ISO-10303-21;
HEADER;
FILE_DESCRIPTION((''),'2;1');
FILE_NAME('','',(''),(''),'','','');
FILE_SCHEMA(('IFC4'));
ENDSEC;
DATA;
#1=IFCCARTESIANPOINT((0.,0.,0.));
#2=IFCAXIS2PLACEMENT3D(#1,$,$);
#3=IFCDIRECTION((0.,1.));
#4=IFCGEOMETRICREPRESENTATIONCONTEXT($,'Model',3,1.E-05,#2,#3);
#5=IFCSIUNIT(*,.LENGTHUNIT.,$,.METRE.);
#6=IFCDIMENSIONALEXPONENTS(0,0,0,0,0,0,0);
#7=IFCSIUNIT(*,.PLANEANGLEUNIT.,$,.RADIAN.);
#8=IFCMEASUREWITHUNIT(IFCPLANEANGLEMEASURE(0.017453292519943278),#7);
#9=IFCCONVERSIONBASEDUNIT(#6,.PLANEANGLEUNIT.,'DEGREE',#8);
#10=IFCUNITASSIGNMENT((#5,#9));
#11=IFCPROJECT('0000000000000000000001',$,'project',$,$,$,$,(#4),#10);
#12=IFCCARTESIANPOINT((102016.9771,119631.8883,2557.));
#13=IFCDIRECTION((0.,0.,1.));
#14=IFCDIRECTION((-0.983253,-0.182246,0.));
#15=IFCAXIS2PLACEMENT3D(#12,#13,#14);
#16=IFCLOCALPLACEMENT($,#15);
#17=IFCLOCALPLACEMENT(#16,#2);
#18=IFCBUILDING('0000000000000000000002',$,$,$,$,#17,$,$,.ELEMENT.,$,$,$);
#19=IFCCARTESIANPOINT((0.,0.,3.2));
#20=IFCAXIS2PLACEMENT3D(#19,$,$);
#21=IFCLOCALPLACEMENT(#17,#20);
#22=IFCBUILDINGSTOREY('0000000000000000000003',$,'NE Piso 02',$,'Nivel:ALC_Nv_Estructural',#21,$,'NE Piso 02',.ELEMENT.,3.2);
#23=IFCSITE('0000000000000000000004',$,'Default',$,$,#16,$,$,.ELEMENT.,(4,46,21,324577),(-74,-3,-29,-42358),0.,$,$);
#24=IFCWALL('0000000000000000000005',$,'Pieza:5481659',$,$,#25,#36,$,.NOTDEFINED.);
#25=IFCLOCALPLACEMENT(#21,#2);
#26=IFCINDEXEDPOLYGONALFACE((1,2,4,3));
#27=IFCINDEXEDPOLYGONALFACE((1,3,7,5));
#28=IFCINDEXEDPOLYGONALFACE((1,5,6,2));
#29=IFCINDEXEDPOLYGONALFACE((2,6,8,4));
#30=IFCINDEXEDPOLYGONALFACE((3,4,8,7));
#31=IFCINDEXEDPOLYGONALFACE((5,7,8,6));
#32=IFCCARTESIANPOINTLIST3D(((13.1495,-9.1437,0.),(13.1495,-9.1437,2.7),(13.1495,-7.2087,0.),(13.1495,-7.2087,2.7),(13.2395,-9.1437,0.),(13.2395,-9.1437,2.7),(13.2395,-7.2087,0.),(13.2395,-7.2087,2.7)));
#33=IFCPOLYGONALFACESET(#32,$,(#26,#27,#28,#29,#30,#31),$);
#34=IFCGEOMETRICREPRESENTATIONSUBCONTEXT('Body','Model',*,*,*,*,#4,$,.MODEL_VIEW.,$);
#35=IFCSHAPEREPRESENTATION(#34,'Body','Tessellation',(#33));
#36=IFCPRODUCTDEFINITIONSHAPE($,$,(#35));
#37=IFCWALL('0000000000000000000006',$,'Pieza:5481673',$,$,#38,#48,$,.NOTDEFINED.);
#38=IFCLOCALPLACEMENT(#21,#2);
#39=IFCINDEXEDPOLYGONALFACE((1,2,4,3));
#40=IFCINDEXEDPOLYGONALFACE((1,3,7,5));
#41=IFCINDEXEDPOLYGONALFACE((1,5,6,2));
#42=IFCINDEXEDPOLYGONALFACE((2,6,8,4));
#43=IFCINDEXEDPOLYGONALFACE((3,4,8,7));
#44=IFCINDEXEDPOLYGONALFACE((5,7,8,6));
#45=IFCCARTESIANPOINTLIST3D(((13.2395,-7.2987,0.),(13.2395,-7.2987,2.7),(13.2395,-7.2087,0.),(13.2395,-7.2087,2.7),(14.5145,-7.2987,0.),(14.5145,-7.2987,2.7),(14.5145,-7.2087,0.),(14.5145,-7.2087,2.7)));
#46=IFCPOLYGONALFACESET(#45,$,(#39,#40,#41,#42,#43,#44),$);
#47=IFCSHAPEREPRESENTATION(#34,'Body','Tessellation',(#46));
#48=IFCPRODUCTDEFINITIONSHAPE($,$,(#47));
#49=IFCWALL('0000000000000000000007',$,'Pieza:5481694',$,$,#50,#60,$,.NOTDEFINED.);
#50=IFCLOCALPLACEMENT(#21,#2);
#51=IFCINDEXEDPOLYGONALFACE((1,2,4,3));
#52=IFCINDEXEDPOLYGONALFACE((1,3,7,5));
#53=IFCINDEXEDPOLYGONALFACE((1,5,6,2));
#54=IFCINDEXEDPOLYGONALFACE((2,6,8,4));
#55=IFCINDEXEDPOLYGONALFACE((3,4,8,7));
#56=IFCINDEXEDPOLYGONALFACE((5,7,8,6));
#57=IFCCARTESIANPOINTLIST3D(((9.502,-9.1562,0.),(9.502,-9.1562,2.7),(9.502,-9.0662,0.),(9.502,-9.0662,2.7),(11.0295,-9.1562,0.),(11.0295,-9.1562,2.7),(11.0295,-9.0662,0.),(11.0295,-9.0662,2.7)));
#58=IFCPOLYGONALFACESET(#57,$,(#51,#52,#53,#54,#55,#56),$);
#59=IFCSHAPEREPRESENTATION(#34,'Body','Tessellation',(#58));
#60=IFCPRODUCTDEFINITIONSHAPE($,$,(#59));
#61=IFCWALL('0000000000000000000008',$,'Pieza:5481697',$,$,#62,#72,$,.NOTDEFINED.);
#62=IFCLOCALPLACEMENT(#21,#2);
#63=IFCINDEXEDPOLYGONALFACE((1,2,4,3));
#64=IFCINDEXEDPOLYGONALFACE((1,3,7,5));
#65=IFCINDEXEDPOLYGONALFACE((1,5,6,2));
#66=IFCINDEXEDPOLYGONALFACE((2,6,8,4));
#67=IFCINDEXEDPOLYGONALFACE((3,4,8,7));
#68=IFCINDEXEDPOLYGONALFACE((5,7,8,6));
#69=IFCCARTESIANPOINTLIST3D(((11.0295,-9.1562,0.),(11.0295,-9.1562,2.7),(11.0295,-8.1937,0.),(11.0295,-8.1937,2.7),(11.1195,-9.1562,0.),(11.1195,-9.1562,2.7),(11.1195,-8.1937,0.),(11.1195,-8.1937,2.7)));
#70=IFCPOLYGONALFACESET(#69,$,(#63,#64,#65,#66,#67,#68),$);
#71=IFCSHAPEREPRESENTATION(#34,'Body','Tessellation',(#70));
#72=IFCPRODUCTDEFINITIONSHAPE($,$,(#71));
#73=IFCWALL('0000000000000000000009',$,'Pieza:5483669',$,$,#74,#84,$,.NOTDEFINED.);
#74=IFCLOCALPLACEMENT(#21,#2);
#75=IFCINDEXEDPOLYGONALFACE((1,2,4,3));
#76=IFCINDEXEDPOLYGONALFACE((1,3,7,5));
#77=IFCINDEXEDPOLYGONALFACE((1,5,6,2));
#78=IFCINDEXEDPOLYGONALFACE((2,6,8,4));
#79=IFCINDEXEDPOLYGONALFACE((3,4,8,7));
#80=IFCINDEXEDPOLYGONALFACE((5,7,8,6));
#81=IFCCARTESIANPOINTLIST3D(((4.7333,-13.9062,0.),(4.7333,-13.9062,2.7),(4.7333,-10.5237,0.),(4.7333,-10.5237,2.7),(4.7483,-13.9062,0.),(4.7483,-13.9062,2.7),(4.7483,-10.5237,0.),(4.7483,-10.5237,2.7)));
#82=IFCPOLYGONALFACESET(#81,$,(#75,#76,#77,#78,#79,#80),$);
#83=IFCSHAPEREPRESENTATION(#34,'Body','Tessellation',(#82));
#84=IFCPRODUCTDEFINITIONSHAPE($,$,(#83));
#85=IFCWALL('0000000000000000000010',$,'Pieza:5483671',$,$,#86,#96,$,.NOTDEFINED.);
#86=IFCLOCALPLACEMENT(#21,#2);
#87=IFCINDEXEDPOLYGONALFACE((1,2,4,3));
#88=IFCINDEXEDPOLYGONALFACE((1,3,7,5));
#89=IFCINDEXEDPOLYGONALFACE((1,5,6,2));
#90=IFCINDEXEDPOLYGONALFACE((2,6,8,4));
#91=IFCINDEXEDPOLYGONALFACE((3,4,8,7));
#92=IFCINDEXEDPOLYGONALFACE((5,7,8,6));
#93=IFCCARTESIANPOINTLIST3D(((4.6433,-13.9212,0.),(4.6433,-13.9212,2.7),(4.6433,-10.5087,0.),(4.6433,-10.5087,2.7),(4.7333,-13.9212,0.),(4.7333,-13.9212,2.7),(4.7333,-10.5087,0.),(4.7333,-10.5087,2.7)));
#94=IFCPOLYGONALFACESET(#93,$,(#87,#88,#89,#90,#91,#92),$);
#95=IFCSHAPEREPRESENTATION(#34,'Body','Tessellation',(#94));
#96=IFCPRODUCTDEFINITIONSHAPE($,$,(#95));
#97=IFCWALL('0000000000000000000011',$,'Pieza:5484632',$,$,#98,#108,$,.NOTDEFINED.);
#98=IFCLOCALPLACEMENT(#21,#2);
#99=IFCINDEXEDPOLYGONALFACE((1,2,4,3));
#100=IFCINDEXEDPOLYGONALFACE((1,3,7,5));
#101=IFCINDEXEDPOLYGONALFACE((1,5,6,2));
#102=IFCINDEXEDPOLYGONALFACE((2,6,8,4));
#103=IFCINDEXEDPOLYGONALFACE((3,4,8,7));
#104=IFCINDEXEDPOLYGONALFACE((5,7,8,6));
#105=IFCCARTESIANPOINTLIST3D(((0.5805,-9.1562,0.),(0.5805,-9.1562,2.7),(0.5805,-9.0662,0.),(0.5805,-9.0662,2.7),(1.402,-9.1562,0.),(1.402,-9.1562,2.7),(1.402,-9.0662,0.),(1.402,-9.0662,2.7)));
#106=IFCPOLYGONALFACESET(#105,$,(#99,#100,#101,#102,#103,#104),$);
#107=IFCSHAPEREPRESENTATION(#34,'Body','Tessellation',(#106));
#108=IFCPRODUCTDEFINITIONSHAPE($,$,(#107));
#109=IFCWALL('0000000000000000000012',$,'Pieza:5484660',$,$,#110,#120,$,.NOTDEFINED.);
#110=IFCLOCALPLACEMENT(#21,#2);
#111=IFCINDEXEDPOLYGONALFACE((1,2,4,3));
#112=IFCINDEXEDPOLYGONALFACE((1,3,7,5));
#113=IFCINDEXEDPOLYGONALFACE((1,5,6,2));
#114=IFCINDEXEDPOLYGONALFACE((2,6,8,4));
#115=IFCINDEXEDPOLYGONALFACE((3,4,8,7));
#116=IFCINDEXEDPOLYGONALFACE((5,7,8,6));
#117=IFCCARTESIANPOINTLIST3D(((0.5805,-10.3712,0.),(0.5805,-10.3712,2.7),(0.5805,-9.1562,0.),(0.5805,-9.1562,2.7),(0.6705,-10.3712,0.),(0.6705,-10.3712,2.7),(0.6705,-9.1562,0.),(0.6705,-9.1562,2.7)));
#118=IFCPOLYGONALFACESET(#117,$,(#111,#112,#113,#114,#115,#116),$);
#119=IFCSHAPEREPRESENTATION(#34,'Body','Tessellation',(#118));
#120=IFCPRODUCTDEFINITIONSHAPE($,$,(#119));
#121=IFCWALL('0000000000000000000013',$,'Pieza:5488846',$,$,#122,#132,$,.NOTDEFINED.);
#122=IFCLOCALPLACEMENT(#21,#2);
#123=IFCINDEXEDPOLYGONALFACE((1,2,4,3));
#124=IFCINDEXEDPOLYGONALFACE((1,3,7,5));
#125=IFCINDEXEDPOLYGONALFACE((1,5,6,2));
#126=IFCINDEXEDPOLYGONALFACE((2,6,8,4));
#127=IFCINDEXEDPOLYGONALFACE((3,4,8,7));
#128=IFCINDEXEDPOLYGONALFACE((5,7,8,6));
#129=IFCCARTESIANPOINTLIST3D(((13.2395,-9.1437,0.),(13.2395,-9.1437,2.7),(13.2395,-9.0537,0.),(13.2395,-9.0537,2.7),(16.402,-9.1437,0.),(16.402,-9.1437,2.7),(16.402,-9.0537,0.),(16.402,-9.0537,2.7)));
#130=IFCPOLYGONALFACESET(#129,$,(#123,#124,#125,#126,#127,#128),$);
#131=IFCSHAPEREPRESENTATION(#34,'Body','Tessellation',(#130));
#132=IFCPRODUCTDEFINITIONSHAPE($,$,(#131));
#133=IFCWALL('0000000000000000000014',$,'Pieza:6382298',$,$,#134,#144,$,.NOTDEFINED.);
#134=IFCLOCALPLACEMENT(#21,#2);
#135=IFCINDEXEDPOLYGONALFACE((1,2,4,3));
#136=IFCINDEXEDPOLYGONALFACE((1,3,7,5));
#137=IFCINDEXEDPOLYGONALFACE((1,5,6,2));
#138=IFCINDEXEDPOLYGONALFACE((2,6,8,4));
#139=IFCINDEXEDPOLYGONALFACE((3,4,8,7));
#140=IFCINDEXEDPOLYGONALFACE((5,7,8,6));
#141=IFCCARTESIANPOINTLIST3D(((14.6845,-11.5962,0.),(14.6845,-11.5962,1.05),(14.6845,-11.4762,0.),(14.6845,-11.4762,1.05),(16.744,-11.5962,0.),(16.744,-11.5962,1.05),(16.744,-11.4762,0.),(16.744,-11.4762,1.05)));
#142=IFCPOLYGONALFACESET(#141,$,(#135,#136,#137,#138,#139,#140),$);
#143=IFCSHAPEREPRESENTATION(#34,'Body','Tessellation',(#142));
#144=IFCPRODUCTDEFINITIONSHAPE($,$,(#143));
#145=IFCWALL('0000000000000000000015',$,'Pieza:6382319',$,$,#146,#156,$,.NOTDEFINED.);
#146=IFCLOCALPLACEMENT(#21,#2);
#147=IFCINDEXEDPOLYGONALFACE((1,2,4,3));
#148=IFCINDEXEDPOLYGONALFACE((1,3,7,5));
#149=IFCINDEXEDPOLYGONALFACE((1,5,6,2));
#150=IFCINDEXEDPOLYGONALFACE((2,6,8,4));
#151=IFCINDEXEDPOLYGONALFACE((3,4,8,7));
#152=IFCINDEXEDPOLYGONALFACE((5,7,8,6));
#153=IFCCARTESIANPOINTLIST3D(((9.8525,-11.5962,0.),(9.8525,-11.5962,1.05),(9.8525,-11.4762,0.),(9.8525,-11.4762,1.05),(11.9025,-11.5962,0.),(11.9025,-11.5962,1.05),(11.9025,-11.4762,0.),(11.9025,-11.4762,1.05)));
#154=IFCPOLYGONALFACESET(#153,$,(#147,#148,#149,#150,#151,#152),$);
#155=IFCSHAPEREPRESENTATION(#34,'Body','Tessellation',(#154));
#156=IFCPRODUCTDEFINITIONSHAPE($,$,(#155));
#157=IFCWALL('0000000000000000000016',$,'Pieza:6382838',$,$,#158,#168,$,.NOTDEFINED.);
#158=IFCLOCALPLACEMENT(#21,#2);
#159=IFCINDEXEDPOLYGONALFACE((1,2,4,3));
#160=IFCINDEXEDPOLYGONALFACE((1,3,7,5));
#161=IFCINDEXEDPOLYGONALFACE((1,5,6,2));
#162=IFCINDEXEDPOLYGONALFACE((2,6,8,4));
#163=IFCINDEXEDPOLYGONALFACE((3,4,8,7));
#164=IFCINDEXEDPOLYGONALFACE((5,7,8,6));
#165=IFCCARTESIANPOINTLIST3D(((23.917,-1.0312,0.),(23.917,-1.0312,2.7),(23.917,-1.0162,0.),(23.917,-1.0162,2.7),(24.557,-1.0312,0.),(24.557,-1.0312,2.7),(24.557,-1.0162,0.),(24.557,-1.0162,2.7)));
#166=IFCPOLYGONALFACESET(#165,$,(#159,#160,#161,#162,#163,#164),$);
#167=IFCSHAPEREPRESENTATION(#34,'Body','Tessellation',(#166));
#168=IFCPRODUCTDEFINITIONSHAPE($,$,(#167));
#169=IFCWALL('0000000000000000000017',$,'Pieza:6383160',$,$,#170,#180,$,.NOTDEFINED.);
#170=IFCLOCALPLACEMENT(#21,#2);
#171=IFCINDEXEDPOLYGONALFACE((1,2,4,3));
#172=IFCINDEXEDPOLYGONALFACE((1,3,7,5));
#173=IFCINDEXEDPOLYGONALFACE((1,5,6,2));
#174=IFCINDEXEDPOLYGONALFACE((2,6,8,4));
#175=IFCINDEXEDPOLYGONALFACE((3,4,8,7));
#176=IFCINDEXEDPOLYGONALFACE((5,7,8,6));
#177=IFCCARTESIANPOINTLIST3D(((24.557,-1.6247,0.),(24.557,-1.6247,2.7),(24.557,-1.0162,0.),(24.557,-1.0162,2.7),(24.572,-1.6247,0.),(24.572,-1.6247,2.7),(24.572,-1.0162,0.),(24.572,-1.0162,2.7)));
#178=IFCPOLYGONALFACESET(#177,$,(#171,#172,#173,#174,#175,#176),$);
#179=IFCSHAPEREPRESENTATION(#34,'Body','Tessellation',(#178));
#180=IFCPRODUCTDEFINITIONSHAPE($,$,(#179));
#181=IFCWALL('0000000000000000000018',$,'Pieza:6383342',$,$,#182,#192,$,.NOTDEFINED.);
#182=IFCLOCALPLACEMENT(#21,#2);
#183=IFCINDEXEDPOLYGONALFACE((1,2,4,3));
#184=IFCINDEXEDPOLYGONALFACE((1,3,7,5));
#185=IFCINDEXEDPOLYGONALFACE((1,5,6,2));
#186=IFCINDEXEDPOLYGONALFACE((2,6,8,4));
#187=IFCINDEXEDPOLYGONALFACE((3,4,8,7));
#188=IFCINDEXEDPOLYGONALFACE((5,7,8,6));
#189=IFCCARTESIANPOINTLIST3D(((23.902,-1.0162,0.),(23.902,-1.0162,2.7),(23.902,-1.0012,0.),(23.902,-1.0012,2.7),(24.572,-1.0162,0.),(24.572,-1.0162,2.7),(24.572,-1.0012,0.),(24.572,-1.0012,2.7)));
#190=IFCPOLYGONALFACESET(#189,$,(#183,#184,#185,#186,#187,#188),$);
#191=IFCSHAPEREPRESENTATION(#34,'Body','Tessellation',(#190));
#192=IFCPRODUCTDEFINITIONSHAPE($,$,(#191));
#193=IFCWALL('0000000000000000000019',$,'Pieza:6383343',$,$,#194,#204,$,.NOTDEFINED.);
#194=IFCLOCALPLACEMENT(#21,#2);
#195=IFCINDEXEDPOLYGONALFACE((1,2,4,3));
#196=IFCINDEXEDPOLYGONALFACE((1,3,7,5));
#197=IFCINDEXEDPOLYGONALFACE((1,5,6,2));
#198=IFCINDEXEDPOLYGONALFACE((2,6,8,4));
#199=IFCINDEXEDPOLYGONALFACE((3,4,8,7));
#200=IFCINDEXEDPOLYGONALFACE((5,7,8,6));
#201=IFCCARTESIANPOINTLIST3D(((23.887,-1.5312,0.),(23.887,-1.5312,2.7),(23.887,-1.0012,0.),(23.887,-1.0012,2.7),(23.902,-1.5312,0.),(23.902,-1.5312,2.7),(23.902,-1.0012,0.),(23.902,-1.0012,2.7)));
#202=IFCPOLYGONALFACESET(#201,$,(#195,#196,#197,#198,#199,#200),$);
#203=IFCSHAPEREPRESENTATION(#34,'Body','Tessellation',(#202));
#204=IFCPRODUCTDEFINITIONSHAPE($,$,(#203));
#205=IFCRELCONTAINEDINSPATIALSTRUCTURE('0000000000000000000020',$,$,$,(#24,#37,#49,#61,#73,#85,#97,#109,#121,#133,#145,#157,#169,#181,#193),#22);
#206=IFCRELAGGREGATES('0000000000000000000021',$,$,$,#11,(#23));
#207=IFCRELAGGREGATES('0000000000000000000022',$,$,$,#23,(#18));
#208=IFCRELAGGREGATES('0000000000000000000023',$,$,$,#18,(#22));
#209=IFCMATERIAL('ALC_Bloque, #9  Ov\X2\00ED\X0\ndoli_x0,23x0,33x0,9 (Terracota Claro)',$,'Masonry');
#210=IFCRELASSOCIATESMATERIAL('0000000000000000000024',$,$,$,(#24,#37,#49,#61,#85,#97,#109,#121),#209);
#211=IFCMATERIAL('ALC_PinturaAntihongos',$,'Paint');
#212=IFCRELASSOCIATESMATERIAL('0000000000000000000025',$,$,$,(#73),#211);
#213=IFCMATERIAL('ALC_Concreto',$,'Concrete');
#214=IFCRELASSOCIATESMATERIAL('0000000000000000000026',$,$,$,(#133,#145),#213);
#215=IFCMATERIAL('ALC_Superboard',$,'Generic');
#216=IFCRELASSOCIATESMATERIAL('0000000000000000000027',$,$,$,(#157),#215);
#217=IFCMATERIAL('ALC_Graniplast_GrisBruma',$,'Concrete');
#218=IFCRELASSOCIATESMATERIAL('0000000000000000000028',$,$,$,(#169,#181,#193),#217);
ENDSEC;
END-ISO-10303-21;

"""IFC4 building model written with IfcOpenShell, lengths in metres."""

from ifc_helpers import new_model, entity, si_unit, converted_unit, direction, frame, frame_2d, origin, place, context, subcontext, project, spatial, rectangle, extrude, material, element, save


model = new_model("IFC4")

# Units and contexts
model_context = context("Model", 3, precision=1e-05, world=origin(), true_north=direction((0.0, 1.0)))
body_context = subcontext(model_context, "Body", "Model", "MODEL_VIEW")
ifc_project = project(units=[si_unit("LENGTHUNIT", "METRE"), converted_unit("PLANEANGLEUNIT", "DEGREE", entity("IfcPlaneAngleMeasure", 0.017453292519943278), si_unit("PLANEANGLEUNIT", "RADIAN"), dimensions=[0, 0, 0, 0, 0, 0, 0])], contexts=[model_context])

# Site, building, storey
site_placement = place(None, frame((102016.9771, 119631.8883, 2557.0), z_axis=(0.0, 0.0, 1.0), x_axis=(-0.983253, -0.182246, 0.0)))
site = spatial("IfcSite", under=ifc_project, at=site_placement, Name="Default", CompositionType="ELEMENT", RefLatitude=(4, 46, 21, 324577), RefLongitude=(-74, -3, -29, -42358), RefElevation=0.0)
building_placement = place(site_placement, origin())
building = spatial("IfcBuilding", under=site, at=building_placement, CompositionType="ELEMENT")
storey_placement = place(building_placement, frame((0.0, 0.0, 3.2)))
storey = spatial("IfcBuildingStorey", under=building, at=storey_placement, Name="NE Piso 02", ObjectType="Nivel:ALC_Nv_Estructural", LongName="NE Piso 02", CompositionType="ELEMENT", Elevation=3.2)

# Walls
ifc_material_1 = material(Name="ALC_Bloque, #9  Ovíndoli_x0,23x0,33x0,9 (Terracota Claro)", Category="Masonry")
wall_1_placement = place(storey_placement, origin())
element("IfcWall", 1, at=wall_1_placement, inside=storey, material=ifc_material_1, Name="Pieza:5481659", PredefinedType="NOTDEFINED", context=body_context, shape_type="SweptSolid", body=[
    extrude(rectangle(XDim=1.935, YDim=0.09, at=frame_2d((0.0, 0.0), x_axis=(1.0, 0.0))), frame((13.1945, -8.1762, 0.0), z_axis=(0.0, 0.0, 1.0), x_axis=(0.0, -1.0, 0.0)), (0.0, 0.0, 1.0), 2.7),
])
wall_2_placement = place(storey_placement, origin())
element("IfcWall", 2, at=wall_2_placement, inside=storey, material=ifc_material_1, Name="Pieza:5481673", PredefinedType="NOTDEFINED", context=body_context, shape_type="SweptSolid", body=[
    extrude(rectangle(XDim=0.09, YDim=1.275, at=frame_2d((0.0, 0.0), x_axis=(1.0, 0.0))), frame((13.877, -7.2537, 0.0), z_axis=(0.0, 0.0, 1.0), x_axis=(0.0, -1.0, 0.0)), (0.0, 0.0, 1.0), 2.7),
])
wall_3_placement = place(storey_placement, origin())
element("IfcWall", 3, at=wall_3_placement, inside=storey, material=ifc_material_1, Name="Pieza:5481694", PredefinedType="NOTDEFINED", context=body_context, shape_type="SweptSolid", body=[
    extrude(rectangle(XDim=0.09, YDim=1.5275, at=frame_2d((0.0, 0.0), x_axis=(1.0, 0.0))), frame((10.2658, -9.1112, 0.0), z_axis=(0.0, 0.0, 1.0), x_axis=(0.0, -1.0, 0.0)), (0.0, 0.0, 1.0), 2.7),
])
wall_4_placement = place(storey_placement, origin())
element("IfcWall", 4, at=wall_4_placement, inside=storey, material=ifc_material_1, Name="Pieza:5481697", PredefinedType="NOTDEFINED", context=body_context, shape_type="SweptSolid", body=[
    extrude(rectangle(XDim=0.9625, YDim=0.09, at=frame_2d((0.0, 0.0), x_axis=(1.0, 0.0))), frame((11.0745, -8.6749, 0.0), z_axis=(0.0, 0.0, 1.0), x_axis=(0.0, -1.0, 0.0)), (0.0, 0.0, 1.0), 2.7),
])
ifc_material_2 = material(Name="ALC_PinturaAntihongos", Category="Paint")
wall_5_placement = place(storey_placement, origin())
element("IfcWall", 5, at=wall_5_placement, inside=storey, material=ifc_material_2, Name="Pieza:5483669", PredefinedType="NOTDEFINED", context=body_context, shape_type="SweptSolid", body=[
    extrude(rectangle(XDim=3.3825, YDim=0.015, at=frame_2d((0.0, 0.0), x_axis=(1.0, 0.0))), frame((4.7408, -12.2149, 0.0), z_axis=(0.0, 0.0, 1.0), x_axis=(0.0, -1.0, 0.0)), (0.0, 0.0, 1.0), 2.7),
])
wall_6_placement = place(storey_placement, origin())
element("IfcWall", 6, at=wall_6_placement, inside=storey, material=ifc_material_1, Name="Pieza:5483671", PredefinedType="NOTDEFINED", context=body_context, shape_type="SweptSolid", body=[
    extrude(rectangle(XDim=3.4125, YDim=0.09, at=frame_2d((0.0, 0.0), x_axis=(1.0, 0.0))), frame((4.6883, -12.2149, 0.0), z_axis=(0.0, 0.0, 1.0), x_axis=(0.0, -1.0, 0.0)), (0.0, 0.0, 1.0), 2.7),
])
wall_7_placement = place(storey_placement, origin())
element("IfcWall", 7, at=wall_7_placement, inside=storey, material=ifc_material_1, Name="Pieza:5484632", PredefinedType="NOTDEFINED", context=body_context, shape_type="SweptSolid", body=[
    extrude(rectangle(XDim=0.09, YDim=0.8215, at=frame_2d((0.0, 0.0), x_axis=(1.0, 0.0))), frame((0.9913, -9.1112, 0.0), z_axis=(0.0, 0.0, 1.0), x_axis=(0.0, -1.0, 0.0)), (0.0, 0.0, 1.0), 2.7),
])
wall_8_placement = place(storey_placement, origin())
element("IfcWall", 8, at=wall_8_placement, inside=storey, material=ifc_material_1, Name="Pieza:5484660", PredefinedType="NOTDEFINED", context=body_context, shape_type="SweptSolid", body=[
    extrude(rectangle(XDim=1.215, YDim=0.09, at=frame_2d((0.0, 0.0), x_axis=(1.0, 0.0))), frame((0.6255, -9.7637, 0.0), z_axis=(0.0, 0.0, 1.0), x_axis=(0.0, -1.0, 0.0)), (0.0, 0.0, 1.0), 2.7),
])
wall_9_placement = place(storey_placement, origin())
element("IfcWall", 9, at=wall_9_placement, inside=storey, material=ifc_material_1, Name="Pieza:5488846", PredefinedType="NOTDEFINED", context=body_context, shape_type="SweptSolid", body=[
    extrude(rectangle(XDim=0.09, YDim=3.1625, at=frame_2d((0.0, 0.0), x_axis=(1.0, 0.0))), frame((14.8208, -9.0987, 0.0), z_axis=(0.0, 0.0, 1.0), x_axis=(0.0, -1.0, 0.0)), (0.0, 0.0, 1.0), 2.7),
])
ifc_material_3 = material(Name="ALC_Concreto", Category="Concrete")
wall_10_placement = place(storey_placement, origin())
element("IfcWall", 10, at=wall_10_placement, inside=storey, material=ifc_material_3, Name="Pieza:6382298", PredefinedType="NOTDEFINED", context=body_context, shape_type="SweptSolid", body=[
    extrude(rectangle(XDim=0.12, YDim=2.0595, at=frame_2d((0.0, 0.0), x_axis=(1.0, 0.0))), frame((15.7143, -11.5362, 0.0), z_axis=(0.0, 0.0, 1.0), x_axis=(0.0, -1.0, 0.0)), (0.0, 0.0, 1.0), 1.05),
])
wall_11_placement = place(storey_placement, origin())
element("IfcWall", 11, at=wall_11_placement, inside=storey, material=ifc_material_3, Name="Pieza:6382319", PredefinedType="NOTDEFINED", context=body_context, shape_type="SweptSolid", body=[
    extrude(rectangle(XDim=0.12, YDim=2.05, at=frame_2d((0.0, 0.0), x_axis=(1.0, 0.0))), frame((10.8775, -11.5362, 0.0), z_axis=(0.0, 0.0, 1.0), x_axis=(0.0, -1.0, 0.0)), (0.0, 0.0, 1.0), 1.05),
])
ifc_material_4 = material(Name="ALC_Superboard", Category="Generic")
wall_12_placement = place(storey_placement, origin())
element("IfcWall", 12, at=wall_12_placement, inside=storey, material=ifc_material_4, Name="Pieza:6382838", PredefinedType="NOTDEFINED", context=body_context, shape_type="SweptSolid", body=[
    extrude(rectangle(XDim=0.015, YDim=0.64, at=frame_2d((0.0, 0.0), x_axis=(1.0, 0.0))), frame((24.237, -1.0237, 0.0), z_axis=(0.0, 0.0, 1.0), x_axis=(0.0, -1.0, 0.0)), (0.0, 0.0, 1.0), 2.7),
])
ifc_material_5 = material(Name="ALC_Graniplast_GrisBruma", Category="Concrete")
wall_13_placement = place(storey_placement, origin())
element("IfcWall", 13, at=wall_13_placement, inside=storey, material=ifc_material_5, Name="Pieza:6383160", PredefinedType="NOTDEFINED", context=body_context, shape_type="SweptSolid", body=[
    extrude(rectangle(XDim=0.6085, YDim=0.015, at=frame_2d((0.0, 0.0), x_axis=(1.0, 0.0))), frame((24.5645, -1.3204, 0.0), z_axis=(0.0, 0.0, 1.0), x_axis=(0.0, -1.0, 0.0)), (0.0, 0.0, 1.0), 2.7),
])
wall_14_placement = place(storey_placement, origin())
element("IfcWall", 14, at=wall_14_placement, inside=storey, material=ifc_material_5, Name="Pieza:6383342", PredefinedType="NOTDEFINED", context=body_context, shape_type="SweptSolid", body=[
    extrude(rectangle(XDim=0.015, YDim=0.67, at=frame_2d((0.0, 0.0), x_axis=(1.0, 0.0))), frame((24.237, -1.0087, 0.0), z_axis=(0.0, 0.0, 1.0), x_axis=(0.0, -1.0, 0.0)), (0.0, 0.0, 1.0), 2.7),
])
wall_15_placement = place(storey_placement, origin())
element("IfcWall", 15, at=wall_15_placement, inside=storey, material=ifc_material_5, Name="Pieza:6383343", PredefinedType="NOTDEFINED", context=body_context, shape_type="SweptSolid", body=[
    extrude(rectangle(XDim=0.53, YDim=0.015, at=frame_2d((0.0, 0.0), x_axis=(1.0, 0.0))), frame((23.8945, -1.2662, 0.0), z_axis=(0.0, 0.0, 1.0), x_axis=(0.0, -1.0, 0.0)), (0.0, 0.0, 1.0), 2.7),
])

save(model, "model.ifc")
